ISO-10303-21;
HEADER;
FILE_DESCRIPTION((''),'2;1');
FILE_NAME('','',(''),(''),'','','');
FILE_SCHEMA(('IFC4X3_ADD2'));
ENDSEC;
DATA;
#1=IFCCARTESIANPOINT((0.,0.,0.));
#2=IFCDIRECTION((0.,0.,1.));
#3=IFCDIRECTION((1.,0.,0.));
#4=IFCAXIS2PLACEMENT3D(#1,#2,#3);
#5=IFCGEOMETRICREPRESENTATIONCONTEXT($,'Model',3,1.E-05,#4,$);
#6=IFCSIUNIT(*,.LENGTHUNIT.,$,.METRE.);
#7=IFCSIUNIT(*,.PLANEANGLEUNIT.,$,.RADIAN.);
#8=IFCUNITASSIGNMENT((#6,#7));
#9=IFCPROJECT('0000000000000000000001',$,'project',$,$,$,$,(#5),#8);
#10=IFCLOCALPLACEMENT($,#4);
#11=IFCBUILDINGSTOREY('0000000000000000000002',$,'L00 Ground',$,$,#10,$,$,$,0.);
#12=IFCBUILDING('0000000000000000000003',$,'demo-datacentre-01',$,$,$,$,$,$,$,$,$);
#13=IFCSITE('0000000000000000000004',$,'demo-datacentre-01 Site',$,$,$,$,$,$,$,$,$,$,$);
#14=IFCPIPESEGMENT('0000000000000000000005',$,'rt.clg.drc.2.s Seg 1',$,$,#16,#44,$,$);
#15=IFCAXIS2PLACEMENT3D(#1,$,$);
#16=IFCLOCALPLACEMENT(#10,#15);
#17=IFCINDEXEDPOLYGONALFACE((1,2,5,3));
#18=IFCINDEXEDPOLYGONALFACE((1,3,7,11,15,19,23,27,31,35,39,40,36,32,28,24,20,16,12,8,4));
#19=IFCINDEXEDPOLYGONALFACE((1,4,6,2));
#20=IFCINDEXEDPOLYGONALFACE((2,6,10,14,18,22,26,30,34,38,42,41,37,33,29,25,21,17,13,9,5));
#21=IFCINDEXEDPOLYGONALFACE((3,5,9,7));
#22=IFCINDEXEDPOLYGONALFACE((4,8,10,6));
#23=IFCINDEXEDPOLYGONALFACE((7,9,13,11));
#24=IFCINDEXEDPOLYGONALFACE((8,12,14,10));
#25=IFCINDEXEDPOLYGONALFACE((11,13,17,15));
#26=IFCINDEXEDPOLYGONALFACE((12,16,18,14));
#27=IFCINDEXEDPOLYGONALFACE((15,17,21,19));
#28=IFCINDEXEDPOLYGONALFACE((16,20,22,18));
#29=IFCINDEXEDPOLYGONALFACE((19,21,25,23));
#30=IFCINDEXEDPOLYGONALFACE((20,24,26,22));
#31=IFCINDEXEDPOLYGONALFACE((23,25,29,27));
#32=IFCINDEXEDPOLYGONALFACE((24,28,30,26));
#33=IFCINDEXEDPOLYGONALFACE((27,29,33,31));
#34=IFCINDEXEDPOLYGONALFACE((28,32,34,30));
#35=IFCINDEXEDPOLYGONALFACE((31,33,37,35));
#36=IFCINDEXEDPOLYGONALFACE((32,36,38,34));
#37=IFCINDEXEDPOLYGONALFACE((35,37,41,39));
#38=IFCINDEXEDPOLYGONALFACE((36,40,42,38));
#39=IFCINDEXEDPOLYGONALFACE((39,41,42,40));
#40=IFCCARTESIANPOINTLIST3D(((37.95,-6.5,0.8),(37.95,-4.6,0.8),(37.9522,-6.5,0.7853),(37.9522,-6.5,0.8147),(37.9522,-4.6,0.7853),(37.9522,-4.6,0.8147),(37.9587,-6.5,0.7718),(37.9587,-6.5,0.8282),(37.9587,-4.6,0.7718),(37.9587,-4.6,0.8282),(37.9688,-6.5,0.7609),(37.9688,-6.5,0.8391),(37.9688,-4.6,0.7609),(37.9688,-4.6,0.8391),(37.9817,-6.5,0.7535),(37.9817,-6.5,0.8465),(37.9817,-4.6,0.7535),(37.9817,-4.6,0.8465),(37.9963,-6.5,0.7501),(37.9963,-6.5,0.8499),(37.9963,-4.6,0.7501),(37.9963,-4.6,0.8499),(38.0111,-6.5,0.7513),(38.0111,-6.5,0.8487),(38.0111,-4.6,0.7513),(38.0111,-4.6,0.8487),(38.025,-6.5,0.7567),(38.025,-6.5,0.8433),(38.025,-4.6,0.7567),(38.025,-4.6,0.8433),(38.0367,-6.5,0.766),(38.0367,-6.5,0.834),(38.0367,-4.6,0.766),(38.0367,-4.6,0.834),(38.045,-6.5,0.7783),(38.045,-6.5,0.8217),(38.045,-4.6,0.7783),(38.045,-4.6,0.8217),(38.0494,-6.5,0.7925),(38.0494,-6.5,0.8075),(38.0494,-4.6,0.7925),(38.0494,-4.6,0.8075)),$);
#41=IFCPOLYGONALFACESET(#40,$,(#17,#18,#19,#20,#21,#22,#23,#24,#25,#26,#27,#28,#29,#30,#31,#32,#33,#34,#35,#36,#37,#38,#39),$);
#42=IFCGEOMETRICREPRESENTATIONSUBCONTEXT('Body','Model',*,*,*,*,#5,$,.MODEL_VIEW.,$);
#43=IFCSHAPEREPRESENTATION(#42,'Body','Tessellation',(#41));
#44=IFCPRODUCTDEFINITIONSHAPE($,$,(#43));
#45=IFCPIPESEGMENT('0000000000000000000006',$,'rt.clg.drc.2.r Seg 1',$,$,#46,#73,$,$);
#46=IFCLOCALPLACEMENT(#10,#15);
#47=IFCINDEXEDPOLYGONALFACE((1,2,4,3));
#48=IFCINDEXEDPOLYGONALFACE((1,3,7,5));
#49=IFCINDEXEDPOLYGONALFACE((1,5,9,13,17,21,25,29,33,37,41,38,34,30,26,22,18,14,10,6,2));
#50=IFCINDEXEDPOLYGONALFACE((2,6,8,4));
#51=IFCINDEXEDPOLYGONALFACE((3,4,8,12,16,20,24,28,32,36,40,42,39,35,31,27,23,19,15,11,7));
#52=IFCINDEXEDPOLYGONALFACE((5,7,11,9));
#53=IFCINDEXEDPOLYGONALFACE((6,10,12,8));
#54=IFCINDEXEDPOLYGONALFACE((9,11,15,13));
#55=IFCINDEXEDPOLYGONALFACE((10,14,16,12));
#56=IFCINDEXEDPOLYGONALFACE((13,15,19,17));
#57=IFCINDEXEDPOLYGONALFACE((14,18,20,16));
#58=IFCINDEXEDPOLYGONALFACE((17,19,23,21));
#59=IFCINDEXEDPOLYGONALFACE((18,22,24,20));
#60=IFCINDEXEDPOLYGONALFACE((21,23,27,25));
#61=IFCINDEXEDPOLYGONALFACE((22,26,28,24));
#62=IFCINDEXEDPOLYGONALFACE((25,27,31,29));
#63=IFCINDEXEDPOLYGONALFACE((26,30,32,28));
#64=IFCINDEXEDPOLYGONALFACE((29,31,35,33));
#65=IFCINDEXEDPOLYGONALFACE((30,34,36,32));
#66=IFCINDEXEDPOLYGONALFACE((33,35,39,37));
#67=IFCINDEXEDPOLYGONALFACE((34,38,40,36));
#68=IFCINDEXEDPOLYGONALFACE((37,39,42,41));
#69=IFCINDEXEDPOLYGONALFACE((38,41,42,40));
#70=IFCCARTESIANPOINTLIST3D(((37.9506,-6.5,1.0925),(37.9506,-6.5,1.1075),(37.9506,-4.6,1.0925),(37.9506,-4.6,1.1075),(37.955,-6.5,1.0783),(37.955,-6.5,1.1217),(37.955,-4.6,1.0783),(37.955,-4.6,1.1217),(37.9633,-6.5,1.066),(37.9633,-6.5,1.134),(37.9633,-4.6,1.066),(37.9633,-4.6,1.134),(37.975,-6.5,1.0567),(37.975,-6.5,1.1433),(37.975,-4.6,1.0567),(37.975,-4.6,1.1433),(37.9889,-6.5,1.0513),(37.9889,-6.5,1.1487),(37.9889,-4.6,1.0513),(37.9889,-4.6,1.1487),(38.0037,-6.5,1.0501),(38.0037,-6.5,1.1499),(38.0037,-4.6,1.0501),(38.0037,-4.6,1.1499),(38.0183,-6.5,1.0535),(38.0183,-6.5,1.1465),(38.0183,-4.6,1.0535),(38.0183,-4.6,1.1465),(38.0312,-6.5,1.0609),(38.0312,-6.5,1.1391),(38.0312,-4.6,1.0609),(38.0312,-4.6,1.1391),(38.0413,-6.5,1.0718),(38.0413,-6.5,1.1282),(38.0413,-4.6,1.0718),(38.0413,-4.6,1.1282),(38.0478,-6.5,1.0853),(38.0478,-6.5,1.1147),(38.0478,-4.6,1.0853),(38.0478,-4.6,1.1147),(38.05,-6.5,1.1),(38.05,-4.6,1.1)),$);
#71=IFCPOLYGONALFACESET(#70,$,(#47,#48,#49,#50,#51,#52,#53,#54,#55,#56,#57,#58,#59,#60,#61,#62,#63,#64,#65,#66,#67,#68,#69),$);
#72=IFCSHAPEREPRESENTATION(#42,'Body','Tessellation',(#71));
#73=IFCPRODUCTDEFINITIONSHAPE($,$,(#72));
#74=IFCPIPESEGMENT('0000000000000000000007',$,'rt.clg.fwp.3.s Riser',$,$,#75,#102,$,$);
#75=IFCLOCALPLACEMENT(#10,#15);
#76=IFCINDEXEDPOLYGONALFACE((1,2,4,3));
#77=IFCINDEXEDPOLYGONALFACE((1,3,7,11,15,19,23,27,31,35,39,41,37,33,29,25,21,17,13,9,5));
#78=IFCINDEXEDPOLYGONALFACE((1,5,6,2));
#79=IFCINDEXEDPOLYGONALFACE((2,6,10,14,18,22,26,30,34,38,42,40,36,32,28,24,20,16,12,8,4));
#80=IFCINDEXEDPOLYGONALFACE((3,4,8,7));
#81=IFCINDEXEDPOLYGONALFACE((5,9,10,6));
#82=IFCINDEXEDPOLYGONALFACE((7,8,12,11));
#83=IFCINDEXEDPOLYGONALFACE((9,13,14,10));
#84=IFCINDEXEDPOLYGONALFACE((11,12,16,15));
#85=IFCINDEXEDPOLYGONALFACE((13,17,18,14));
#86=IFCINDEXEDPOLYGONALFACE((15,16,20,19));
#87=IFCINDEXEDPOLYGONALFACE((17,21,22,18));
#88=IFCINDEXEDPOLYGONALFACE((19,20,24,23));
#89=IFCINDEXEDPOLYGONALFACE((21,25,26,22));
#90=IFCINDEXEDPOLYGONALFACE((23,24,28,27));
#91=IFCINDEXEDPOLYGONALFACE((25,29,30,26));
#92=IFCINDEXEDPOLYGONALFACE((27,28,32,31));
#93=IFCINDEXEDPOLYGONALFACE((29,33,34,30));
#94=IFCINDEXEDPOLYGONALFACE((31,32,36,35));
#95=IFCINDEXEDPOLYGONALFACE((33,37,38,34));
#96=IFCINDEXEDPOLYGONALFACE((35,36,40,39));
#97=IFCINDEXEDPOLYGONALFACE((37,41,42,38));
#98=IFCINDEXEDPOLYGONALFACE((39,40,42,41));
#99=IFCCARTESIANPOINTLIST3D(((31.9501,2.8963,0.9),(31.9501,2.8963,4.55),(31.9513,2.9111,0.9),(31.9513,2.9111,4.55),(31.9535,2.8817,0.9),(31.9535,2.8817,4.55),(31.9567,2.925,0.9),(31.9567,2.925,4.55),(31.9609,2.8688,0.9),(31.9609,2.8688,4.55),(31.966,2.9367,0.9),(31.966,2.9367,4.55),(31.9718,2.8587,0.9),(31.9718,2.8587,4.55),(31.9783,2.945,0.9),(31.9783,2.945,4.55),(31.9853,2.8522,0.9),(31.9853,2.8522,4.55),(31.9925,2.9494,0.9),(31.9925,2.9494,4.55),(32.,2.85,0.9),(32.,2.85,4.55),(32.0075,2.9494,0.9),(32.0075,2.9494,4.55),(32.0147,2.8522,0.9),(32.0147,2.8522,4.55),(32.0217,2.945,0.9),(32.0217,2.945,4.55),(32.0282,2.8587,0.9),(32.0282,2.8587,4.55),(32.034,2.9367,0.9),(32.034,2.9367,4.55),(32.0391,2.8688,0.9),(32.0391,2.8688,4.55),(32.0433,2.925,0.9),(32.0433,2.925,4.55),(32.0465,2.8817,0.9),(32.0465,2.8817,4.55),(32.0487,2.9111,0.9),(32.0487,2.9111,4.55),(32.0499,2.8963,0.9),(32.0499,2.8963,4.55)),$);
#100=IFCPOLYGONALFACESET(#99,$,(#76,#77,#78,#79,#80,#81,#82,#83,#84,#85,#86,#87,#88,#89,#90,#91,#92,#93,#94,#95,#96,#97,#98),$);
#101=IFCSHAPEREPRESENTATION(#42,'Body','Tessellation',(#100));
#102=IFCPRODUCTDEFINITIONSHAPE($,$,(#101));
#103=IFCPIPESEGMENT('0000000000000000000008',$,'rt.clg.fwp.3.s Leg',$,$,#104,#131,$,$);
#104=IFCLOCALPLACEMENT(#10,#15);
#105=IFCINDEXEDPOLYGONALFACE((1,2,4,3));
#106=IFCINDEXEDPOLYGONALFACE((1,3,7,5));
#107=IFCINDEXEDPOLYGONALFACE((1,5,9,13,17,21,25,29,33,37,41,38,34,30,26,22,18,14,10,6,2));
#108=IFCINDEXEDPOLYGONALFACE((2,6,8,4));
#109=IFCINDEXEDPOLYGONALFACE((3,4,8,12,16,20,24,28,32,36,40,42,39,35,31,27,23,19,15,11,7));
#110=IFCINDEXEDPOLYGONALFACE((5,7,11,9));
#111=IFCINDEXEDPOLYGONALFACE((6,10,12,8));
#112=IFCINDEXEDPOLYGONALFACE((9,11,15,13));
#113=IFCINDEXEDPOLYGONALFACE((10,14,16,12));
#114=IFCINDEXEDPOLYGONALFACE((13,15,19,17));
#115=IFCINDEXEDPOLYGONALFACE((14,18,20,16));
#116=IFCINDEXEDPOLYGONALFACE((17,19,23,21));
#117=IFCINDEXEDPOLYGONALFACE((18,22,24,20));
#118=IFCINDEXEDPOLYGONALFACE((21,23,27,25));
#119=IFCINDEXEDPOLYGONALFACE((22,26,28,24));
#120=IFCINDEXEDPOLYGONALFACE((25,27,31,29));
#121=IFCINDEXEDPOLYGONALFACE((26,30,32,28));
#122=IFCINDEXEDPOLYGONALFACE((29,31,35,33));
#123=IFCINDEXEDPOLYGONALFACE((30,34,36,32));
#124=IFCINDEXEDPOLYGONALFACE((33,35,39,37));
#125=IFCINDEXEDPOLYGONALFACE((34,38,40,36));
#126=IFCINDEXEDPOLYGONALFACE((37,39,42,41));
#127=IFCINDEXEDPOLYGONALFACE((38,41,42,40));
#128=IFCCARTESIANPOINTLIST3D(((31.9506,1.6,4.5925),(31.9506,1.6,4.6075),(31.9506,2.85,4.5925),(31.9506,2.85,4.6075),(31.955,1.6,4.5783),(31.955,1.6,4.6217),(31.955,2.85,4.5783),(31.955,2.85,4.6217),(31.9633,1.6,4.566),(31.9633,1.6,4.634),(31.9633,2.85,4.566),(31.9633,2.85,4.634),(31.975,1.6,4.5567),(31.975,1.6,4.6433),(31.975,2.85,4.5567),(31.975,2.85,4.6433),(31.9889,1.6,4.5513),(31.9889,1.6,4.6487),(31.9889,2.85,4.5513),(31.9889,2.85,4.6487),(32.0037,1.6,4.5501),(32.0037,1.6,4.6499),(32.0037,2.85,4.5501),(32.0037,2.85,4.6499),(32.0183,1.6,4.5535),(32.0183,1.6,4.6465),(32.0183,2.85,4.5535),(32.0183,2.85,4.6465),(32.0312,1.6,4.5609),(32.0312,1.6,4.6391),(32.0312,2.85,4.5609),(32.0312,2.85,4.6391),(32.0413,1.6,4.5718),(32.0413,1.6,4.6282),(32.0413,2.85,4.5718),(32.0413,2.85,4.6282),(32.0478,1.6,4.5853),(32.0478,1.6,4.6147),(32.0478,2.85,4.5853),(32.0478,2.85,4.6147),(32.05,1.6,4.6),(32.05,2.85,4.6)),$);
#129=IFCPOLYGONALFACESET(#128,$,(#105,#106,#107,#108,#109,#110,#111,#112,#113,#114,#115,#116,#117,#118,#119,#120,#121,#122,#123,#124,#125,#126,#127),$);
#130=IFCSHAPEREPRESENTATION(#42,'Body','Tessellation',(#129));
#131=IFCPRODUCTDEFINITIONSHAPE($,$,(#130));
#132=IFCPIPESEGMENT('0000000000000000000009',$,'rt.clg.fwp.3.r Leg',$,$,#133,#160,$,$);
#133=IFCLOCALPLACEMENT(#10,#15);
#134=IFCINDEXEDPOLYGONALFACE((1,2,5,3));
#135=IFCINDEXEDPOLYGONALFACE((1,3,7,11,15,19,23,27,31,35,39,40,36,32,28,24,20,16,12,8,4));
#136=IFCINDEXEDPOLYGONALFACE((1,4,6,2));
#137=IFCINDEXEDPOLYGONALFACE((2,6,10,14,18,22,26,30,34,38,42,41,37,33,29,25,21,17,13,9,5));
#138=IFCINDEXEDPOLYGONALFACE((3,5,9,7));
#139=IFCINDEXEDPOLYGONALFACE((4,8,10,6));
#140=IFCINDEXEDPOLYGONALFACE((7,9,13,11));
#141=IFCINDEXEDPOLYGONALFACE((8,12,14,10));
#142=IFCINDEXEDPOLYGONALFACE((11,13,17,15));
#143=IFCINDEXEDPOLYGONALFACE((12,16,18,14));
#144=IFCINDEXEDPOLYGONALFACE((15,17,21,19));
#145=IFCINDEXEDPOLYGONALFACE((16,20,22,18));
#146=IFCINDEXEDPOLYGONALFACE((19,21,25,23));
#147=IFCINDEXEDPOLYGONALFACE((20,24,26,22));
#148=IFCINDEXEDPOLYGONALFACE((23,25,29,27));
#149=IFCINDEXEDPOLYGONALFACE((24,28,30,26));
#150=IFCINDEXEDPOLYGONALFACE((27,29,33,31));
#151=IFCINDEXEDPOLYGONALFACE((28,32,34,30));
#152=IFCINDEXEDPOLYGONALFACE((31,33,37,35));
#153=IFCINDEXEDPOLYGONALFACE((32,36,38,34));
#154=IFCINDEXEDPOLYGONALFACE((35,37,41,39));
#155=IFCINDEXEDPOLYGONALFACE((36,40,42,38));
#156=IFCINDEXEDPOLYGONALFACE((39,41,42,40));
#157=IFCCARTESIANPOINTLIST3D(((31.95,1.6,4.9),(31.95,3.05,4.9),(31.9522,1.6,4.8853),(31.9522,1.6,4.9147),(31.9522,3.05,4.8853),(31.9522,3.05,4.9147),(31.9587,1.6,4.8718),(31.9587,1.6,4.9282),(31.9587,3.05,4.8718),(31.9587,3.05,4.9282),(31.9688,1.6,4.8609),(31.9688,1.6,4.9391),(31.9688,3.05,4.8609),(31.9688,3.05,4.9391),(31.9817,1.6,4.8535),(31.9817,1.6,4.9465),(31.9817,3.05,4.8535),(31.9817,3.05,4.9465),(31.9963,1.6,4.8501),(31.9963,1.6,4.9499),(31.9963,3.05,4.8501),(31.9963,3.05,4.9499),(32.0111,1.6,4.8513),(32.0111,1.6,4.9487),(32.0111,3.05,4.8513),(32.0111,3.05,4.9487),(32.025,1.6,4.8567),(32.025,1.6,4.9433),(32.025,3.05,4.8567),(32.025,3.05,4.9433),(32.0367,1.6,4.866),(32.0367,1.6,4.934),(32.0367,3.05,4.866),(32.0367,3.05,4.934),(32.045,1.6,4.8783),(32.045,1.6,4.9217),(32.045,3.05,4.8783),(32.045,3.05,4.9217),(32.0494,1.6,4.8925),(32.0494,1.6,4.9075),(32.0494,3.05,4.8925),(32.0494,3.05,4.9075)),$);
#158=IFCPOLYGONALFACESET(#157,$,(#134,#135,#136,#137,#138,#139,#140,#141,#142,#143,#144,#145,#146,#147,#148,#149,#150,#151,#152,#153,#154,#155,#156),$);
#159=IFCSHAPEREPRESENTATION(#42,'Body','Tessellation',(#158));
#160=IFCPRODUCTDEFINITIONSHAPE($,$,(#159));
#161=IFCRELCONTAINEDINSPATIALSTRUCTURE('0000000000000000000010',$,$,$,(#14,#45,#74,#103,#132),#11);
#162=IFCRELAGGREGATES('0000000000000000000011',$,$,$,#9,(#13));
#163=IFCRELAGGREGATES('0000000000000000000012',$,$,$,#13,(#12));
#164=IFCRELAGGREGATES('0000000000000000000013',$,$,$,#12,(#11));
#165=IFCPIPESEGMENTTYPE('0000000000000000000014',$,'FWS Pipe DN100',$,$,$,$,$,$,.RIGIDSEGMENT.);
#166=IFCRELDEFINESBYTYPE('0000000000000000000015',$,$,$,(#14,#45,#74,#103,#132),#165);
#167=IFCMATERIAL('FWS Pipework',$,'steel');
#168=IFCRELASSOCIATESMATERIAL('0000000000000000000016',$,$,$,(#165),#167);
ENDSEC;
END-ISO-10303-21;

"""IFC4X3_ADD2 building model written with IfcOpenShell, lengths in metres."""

from ifc_helpers import new_model, si_unit, frame, origin_with_axes, place, context, subcontext, project, spatial, circle, extrude, material, type_object, element, save


model = new_model("IFC4X3_ADD2")

# Units and contexts
model_context = context("Model", 3, precision=1e-05, world=origin_with_axes())
body_context = subcontext(model_context, "Body", "Model", "MODEL_VIEW")
ifc_project = project(units=[si_unit("LENGTHUNIT", "METRE"), si_unit("PLANEANGLEUNIT", "RADIAN")], contexts=[model_context])

# Site, building, storey
site = spatial("IfcSite", under=ifc_project, Name="demo-datacentre-01 Site")
building = spatial("IfcBuilding", under=site, Name="demo-datacentre-01")
storey_placement = place(None, origin_with_axes())
storey = spatial("IfcBuildingStorey", under=building, at=storey_placement, Name="L00 Ground", Elevation=0.0)

# Shared definitions
ifc_material = material(Name="FWS Pipework", Category="steel")

# Pipe segments
pipe_segment_type_1 = type_object("IfcPipeSegmentType", Name="FWS Pipe DN100", PredefinedType="RIGIDSEGMENT", material=ifc_material)
for number, where, z_axis, x_axis, name in (
    (1, (38.0, -6.5, 0.8), (0.0, 1.0, 0.0), (-1.0, 0.0, 0.0), "rt.clg.drc.2.s Seg 1"),
    (2, (38.0, -4.6, 1.1), (0.0, -1.0, 0.0), (1.0, 0.0, 0.0), "rt.clg.drc.2.r Seg 1"),
):
    element("IfcPipeSegment", number, at=place(storey_placement, frame(where, z_axis=z_axis, x_axis=x_axis)), inside=storey, type_object=pipe_segment_type_1, Name=name, context=body_context, shape_type="SweptSolid", body=[
        extrude(circle(Radius=0.05), origin_with_axes(), (0.0, 0.0, 1.0), 1.9),
    ])
pipe_segment_1_placement = place(storey_placement, frame((32.0, 2.9, 0.9), z_axis=(0.0, 0.0, 1.0), x_axis=(0.0, -1.0, 0.0)))
element("IfcPipeSegment", 3, at=pipe_segment_1_placement, inside=storey, type_object=pipe_segment_type_1, Name="rt.clg.fwp.3.s Riser", context=body_context, shape_type="SweptSolid", body=[
    extrude(circle(Radius=0.05), origin_with_axes(), (0.0, 0.0, 1.0), 3.65),
])
pipe_segment_2_placement = place(storey_placement, frame((32.0, 2.85, 4.6), z_axis=(0.0, -1.0, 0.0), x_axis=(1.0, 0.0, 0.0)))
element("IfcPipeSegment", 4, at=pipe_segment_2_placement, inside=storey, type_object=pipe_segment_type_1, Name="rt.clg.fwp.3.s Leg", context=body_context, shape_type="SweptSolid", body=[
    extrude(circle(Radius=0.05), origin_with_axes(), (0.0, 0.0, 1.0), 1.25),
])
pipe_segment_3_placement = place(storey_placement, frame((32.0, 1.6, 4.9), z_axis=(0.0, 1.0, 0.0), x_axis=(-1.0, 0.0, 0.0)))
element("IfcPipeSegment", 5, at=pipe_segment_3_placement, inside=storey, type_object=pipe_segment_type_1, Name="rt.clg.fwp.3.r Leg", context=body_context, shape_type="SweptSolid", body=[
    extrude(circle(Radius=0.05), origin_with_axes(), (0.0, 0.0, 1.0), 1.45),
])

save(model, "model.ifc")
